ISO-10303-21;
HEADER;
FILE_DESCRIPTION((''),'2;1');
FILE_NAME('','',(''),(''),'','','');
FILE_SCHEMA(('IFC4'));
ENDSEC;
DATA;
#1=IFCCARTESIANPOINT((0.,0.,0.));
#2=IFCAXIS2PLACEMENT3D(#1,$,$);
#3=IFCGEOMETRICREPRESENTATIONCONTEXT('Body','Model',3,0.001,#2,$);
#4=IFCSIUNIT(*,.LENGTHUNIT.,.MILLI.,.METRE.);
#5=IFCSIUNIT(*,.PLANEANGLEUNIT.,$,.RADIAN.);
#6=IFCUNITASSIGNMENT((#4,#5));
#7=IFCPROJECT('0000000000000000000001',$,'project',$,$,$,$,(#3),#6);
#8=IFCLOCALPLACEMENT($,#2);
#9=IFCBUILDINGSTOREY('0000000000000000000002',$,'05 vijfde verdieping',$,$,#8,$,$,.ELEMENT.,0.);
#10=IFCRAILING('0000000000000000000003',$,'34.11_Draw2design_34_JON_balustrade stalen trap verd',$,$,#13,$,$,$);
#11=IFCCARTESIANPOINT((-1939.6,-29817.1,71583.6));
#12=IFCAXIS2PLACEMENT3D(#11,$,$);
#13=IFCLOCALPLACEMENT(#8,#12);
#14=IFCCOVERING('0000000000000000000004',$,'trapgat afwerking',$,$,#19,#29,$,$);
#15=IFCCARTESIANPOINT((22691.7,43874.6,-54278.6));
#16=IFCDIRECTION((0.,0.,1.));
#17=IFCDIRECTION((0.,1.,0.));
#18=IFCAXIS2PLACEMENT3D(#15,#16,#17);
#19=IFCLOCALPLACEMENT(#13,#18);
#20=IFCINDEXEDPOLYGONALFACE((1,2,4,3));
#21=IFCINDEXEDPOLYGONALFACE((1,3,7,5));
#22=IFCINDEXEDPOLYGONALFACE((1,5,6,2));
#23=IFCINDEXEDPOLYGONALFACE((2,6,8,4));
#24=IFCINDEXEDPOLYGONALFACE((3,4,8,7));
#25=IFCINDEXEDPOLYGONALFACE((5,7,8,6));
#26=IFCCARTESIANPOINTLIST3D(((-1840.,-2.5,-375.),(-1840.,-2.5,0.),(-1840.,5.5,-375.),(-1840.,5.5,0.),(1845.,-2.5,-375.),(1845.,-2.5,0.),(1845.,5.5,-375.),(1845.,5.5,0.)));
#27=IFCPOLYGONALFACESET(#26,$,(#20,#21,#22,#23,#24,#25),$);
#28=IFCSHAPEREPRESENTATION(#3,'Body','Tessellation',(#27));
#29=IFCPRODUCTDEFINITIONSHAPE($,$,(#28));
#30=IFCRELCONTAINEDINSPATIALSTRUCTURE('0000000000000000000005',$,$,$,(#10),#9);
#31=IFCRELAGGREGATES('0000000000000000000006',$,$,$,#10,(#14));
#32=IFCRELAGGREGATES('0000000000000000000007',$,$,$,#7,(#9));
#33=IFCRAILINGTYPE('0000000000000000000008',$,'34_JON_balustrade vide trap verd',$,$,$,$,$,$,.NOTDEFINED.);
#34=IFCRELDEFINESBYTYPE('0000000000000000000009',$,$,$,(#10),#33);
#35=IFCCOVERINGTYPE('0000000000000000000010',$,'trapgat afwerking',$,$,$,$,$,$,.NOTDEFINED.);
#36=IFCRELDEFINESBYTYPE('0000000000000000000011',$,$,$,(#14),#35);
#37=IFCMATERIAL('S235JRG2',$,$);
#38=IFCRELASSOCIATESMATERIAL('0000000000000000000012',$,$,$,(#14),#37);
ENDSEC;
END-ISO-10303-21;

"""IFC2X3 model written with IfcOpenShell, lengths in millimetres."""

from ifc_helpers import new_model, si_unit, frame, origin, place, context, project, spatial, polyline, outline, extrude, source, transform, mapped, material, type_object, element, aggregate, save


model = new_model("IFC2X3")

# Units and contexts
model_context = context("Model", 3, precision=0.001, world=origin(), identifier="Body")
ifc_project = project(units=[si_unit("LENGTHUNIT", "METRE", prefix="MILLI"), si_unit("PLANEANGLEUNIT", "RADIAN")], contexts=[model_context])

# Storey
storey_placement = place(None, origin())
storey = spatial("IfcBuildingStorey", under=ifc_project, at=storey_placement, Name="05 vijfde verdieping", CompositionType="ELEMENT", Elevation=0.0)

# Shared definitions
ifc_material_1 = material(Name="S235JRG2")

# Railing, covering
railing_type = type_object("IfcRailingType", Name="34_JON_balustrade vide trap verd")
railing_placement = place(storey_placement, frame((-1939.6, -29817.1, 71583.6)))
railing = element("IfcRailing", 1, at=railing_placement, inside=storey, type_object=railing_type, Name="34.11_Draw2design_34_JON_balustrade stalen trap verd")
covering_type = type_object("IfcCoveringType", Name="trapgat afwerking")
shared_shape_1 = source(origin(), model_context, "Body", "SweptSolid", [
    extrude(outline(polyline([(-1840.0, -2.5), (1845.0, -2.5), (1845.0, 5.5), (-1840.0, 5.5), (-1840.0, -2.5)])), origin(), (0.0, 0.0, -1.0), 375.0),
])
covering_placement = place(railing_placement, frame((22691.7, 43874.6, -54278.6), z_axis=(0.0, 0.0, 1.0), x_axis=(0.0, 1.0, 0.0)))
covering = element("IfcCovering", 2, at=covering_placement, type_object=covering_type, material=ifc_material_1, Name="trapgat afwerking", context=model_context, shape_type="MappedRepresentation", body=[
    mapped(shared_shape_1, transform((0.0, 0.0, 0.0), scale=1.0)),
])
aggregate(railing, [covering])

save(model, "model.ifc")
